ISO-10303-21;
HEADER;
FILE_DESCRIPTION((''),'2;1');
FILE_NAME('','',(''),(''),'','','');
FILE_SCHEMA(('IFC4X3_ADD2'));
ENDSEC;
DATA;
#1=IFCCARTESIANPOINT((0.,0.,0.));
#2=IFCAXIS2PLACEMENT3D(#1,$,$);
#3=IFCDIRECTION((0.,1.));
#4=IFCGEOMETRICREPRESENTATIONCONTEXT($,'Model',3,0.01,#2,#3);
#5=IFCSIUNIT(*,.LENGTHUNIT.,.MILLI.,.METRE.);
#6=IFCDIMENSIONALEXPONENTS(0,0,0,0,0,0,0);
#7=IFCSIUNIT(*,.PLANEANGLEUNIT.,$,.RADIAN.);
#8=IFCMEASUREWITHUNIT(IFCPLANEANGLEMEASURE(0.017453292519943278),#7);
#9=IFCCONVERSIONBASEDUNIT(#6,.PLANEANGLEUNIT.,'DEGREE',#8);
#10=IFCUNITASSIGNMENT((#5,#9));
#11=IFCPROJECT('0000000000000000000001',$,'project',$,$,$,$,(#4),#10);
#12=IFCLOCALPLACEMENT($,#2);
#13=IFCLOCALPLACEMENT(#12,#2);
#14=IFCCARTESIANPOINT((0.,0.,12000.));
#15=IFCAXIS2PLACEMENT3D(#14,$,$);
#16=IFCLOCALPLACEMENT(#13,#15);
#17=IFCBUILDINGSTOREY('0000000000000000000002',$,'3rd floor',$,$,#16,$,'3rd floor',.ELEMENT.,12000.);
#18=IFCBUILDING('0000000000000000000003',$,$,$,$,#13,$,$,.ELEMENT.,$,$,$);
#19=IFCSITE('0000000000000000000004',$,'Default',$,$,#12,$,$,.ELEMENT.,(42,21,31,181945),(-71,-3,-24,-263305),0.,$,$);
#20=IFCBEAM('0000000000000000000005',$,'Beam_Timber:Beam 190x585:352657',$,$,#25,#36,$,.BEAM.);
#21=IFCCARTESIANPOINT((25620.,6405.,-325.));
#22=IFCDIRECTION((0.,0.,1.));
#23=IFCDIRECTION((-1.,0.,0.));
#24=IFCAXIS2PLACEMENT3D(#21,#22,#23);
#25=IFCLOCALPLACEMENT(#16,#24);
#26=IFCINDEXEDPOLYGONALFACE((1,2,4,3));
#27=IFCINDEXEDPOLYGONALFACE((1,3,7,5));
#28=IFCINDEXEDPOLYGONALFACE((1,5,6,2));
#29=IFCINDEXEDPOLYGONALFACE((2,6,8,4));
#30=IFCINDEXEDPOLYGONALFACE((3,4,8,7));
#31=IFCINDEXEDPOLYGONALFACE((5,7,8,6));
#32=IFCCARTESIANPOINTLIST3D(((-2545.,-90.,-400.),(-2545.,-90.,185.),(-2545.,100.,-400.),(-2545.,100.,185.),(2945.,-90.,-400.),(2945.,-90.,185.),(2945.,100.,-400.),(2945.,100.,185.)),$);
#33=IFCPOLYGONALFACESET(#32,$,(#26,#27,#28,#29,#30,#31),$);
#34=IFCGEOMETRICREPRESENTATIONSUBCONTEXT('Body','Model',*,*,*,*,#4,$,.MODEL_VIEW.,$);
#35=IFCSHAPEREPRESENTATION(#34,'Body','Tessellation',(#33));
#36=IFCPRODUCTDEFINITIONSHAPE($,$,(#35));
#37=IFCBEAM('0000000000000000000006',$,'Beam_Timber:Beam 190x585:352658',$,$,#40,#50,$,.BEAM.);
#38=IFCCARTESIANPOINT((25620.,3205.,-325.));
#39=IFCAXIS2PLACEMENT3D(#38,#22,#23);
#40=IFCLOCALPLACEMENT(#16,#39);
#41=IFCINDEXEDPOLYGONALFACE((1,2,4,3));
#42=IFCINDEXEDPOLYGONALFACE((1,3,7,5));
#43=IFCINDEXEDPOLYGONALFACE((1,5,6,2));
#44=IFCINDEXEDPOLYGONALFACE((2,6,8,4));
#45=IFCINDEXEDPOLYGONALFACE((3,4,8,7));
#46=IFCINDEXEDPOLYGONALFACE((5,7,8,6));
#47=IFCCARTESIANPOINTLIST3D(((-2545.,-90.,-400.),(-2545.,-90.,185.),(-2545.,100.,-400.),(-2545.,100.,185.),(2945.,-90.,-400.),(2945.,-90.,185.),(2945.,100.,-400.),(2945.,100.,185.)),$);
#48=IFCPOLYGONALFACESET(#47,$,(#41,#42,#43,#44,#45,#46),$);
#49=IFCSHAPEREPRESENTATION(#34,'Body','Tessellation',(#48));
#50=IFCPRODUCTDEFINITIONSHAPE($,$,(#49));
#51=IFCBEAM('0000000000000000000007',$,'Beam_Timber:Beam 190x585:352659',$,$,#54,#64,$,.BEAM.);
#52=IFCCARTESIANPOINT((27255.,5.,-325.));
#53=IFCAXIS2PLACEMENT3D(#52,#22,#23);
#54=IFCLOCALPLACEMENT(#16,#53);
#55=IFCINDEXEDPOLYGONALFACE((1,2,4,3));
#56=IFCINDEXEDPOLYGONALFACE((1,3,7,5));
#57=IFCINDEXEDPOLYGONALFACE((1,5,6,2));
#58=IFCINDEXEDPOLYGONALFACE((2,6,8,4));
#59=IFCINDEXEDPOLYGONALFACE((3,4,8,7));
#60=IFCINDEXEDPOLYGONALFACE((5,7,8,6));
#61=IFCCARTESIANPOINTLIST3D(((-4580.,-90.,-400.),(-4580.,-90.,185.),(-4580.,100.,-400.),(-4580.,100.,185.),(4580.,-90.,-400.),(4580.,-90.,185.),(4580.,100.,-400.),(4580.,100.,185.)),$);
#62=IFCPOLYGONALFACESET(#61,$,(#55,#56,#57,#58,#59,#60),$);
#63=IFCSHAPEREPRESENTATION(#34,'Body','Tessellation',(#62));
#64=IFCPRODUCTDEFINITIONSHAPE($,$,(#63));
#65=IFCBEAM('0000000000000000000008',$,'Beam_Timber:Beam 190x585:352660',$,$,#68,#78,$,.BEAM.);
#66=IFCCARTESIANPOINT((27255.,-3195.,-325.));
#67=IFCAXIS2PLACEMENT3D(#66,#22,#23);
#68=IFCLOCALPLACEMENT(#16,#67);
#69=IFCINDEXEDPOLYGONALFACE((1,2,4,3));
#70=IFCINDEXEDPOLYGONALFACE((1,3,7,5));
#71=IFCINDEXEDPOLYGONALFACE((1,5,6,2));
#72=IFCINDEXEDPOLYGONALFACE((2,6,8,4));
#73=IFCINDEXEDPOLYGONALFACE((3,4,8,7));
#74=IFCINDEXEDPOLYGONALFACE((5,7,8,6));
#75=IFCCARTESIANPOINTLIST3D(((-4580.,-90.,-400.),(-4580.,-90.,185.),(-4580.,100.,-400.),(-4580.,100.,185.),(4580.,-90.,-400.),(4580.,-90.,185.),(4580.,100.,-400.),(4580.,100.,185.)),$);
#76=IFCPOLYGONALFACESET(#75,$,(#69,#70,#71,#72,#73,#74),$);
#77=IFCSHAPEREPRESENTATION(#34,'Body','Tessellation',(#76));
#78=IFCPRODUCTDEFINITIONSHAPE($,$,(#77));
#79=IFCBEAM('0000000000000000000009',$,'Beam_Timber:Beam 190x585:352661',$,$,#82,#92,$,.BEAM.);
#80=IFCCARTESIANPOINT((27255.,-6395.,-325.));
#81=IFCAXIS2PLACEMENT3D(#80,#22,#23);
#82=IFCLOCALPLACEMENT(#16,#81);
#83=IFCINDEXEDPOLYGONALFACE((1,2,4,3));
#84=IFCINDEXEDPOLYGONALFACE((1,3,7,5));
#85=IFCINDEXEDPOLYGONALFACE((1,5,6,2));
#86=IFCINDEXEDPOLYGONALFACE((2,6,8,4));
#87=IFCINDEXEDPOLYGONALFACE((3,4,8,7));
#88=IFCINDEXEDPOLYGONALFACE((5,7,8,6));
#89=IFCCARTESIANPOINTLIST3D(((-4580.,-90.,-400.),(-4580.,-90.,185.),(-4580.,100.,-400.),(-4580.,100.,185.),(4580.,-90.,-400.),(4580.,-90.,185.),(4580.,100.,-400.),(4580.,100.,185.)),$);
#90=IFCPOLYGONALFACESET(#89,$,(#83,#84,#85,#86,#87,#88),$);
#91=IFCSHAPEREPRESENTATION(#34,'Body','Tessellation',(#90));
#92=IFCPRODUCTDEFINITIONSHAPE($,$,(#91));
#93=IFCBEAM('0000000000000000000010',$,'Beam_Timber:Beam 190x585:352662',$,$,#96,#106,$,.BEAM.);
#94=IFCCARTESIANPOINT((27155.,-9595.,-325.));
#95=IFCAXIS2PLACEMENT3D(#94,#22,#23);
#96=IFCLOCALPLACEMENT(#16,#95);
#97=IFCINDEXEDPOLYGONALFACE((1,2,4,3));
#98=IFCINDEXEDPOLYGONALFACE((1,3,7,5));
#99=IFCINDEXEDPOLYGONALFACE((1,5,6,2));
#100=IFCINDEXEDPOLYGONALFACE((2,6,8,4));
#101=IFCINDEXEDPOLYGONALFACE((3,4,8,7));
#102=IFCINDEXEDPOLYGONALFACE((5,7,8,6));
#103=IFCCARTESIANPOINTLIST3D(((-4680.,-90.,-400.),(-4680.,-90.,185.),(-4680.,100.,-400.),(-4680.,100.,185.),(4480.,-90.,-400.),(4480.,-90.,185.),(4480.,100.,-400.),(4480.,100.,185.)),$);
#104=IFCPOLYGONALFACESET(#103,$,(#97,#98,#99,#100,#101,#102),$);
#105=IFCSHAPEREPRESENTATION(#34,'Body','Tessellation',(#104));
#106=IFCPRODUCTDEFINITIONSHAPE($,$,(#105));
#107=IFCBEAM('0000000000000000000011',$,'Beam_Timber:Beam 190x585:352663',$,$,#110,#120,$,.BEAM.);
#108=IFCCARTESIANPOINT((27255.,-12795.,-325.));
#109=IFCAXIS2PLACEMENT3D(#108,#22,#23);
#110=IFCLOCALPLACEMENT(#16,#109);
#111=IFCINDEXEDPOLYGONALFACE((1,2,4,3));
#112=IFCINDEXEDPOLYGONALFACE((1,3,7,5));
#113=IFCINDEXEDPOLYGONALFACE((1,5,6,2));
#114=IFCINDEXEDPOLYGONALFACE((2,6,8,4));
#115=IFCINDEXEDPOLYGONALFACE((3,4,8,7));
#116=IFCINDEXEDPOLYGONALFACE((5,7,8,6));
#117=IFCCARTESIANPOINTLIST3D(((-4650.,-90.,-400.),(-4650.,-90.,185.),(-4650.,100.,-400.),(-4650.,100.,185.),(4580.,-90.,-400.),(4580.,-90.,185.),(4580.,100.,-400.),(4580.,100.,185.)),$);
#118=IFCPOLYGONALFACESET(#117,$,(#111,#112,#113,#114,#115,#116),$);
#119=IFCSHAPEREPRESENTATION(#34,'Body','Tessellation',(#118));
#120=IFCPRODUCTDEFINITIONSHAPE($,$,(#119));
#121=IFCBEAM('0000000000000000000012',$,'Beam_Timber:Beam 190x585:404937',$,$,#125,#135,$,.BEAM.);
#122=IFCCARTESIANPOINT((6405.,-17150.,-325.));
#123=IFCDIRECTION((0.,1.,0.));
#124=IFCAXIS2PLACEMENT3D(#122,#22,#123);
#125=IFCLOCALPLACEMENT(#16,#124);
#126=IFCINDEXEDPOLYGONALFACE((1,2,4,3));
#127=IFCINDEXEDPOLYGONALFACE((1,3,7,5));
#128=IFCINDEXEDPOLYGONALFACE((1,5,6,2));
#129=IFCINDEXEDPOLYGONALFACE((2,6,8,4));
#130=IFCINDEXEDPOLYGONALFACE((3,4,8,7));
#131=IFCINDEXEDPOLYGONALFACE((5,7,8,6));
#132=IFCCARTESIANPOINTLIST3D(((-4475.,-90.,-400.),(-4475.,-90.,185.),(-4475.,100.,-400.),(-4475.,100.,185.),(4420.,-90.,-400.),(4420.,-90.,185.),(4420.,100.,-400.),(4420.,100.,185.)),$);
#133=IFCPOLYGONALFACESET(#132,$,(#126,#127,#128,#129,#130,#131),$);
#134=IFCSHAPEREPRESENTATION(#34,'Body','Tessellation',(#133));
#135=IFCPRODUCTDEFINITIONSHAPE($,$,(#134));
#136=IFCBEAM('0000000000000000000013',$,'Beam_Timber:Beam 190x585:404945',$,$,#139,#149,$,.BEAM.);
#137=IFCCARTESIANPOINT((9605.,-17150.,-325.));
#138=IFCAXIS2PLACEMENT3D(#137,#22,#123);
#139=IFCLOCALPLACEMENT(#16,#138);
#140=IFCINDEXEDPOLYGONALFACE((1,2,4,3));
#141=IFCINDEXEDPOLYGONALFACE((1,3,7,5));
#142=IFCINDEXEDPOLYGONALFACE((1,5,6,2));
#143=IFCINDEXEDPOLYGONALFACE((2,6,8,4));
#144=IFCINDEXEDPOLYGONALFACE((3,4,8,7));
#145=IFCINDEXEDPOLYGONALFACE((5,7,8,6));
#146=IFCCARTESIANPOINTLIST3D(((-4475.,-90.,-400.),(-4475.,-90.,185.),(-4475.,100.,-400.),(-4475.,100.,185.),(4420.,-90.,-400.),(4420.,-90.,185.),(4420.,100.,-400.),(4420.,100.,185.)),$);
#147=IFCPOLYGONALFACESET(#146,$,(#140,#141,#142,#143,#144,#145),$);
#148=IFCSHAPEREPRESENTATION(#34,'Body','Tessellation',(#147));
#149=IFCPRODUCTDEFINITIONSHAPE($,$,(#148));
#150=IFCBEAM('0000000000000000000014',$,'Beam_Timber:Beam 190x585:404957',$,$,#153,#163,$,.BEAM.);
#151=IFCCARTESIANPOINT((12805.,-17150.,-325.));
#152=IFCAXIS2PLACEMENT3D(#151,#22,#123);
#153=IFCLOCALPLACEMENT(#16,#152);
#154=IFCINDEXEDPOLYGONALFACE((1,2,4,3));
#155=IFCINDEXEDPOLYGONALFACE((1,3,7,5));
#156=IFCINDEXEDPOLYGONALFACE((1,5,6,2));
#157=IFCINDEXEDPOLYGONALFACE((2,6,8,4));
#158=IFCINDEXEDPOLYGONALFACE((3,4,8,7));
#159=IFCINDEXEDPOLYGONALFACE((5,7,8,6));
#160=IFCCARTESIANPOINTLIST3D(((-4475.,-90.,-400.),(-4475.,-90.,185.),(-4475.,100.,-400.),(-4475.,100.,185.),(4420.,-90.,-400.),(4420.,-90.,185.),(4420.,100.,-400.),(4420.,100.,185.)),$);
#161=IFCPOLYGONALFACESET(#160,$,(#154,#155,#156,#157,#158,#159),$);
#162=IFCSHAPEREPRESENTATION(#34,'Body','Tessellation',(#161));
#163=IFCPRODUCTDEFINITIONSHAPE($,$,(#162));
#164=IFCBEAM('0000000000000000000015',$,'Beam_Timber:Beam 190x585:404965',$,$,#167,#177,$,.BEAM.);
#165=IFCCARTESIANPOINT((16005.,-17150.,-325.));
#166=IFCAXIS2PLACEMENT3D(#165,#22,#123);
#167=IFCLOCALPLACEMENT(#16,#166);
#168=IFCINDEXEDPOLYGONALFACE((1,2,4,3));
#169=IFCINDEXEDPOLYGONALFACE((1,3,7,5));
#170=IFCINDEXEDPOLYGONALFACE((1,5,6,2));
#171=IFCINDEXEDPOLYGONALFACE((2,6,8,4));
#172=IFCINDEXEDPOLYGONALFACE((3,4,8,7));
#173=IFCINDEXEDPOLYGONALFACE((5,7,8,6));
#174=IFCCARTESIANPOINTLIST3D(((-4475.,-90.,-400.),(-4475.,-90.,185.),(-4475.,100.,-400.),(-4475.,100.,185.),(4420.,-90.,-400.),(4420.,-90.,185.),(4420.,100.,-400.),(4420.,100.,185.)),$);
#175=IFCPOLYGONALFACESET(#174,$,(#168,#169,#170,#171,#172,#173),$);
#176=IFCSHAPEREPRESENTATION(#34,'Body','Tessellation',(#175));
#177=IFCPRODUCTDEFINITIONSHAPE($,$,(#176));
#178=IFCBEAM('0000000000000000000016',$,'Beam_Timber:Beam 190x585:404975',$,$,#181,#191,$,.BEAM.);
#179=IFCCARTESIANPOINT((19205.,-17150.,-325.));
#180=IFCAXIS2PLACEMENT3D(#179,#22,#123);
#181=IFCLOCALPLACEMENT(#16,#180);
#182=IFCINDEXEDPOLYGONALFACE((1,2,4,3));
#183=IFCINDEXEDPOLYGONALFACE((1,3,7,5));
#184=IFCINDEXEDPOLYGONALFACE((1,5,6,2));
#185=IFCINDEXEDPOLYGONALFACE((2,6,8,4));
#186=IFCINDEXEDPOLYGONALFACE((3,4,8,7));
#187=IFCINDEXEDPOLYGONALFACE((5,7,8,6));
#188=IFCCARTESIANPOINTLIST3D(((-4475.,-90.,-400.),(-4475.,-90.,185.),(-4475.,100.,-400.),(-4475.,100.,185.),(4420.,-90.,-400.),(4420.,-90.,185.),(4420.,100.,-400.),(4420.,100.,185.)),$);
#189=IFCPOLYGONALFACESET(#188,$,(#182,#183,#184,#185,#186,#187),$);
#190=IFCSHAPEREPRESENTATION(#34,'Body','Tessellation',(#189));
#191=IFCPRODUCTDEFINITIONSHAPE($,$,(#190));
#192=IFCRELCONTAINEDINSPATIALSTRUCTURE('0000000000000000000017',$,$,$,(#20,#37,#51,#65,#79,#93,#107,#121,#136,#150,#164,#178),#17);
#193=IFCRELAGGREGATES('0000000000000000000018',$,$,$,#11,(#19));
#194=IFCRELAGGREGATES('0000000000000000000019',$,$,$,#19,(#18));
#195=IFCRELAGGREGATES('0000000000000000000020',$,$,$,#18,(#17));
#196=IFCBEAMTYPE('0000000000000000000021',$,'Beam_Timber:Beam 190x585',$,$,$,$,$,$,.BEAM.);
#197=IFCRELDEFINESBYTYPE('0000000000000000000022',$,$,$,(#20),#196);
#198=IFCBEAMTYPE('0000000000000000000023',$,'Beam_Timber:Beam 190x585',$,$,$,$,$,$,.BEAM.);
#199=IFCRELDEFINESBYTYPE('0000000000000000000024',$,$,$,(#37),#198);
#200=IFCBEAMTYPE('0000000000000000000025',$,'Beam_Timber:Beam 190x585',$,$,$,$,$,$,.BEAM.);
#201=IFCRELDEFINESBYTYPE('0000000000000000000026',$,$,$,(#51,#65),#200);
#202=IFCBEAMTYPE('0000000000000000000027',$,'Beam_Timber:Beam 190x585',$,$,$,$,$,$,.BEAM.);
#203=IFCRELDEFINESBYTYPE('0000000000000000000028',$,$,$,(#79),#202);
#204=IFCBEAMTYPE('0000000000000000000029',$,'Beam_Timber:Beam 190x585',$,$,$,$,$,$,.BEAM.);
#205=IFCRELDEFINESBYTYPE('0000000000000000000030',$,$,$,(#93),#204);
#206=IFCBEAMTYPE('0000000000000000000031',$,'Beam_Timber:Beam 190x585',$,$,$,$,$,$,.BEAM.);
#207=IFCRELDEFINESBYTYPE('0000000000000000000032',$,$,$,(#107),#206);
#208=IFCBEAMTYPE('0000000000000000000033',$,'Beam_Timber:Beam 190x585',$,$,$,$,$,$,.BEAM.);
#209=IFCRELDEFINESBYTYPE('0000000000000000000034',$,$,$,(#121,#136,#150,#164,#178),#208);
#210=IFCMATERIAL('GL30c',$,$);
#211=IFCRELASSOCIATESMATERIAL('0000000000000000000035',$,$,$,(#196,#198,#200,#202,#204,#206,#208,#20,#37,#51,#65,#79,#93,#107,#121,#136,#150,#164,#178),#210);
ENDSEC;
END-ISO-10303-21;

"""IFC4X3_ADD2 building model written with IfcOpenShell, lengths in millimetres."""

from ifc_helpers import new_model, entity, si_unit, converted_unit, direction, frame, origin, origin_2d_with_axis, place, context, subcontext, project, spatial, rectangle, extrude, source, transform, mapped, material, material_profile, profile_set, profile_usage, type_object, type_shapes, element, save


model = new_model("IFC4X3_ADD2")

# Units and contexts
model_context = context("Model", 3, precision=0.01, world=origin(), true_north=direction((0.0, 1.0)))
body_context = subcontext(model_context, "Body", "Model", "MODEL_VIEW")
ifc_project = project(units=[si_unit("LENGTHUNIT", "METRE", prefix="MILLI"), converted_unit("PLANEANGLEUNIT", "DEGREE", entity("IfcPlaneAngleMeasure", 0.017453292519943278), si_unit("PLANEANGLEUNIT", "RADIAN"), dimensions=[0, 0, 0, 0, 0, 0, 0])], contexts=[model_context])

# Site, building, storey
site_placement = place(None, origin())
site = spatial("IfcSite", under=ifc_project, at=site_placement, Name="Default", CompositionType="ELEMENT", RefLatitude=(42, 21, 31, 181945), RefLongitude=(-71, -3, -24, -263305), RefElevation=0.0)
building_placement = place(site_placement, origin())
building = spatial("IfcBuilding", under=site, at=building_placement, CompositionType="ELEMENT")
storey_placement = place(building_placement, frame((0.0, 0.0, 12000.0)))
storey = spatial("IfcBuildingStorey", under=building, at=storey_placement, Name="3rd floor", LongName="3rd floor", CompositionType="ELEMENT", Elevation=12000.0)

# Beams
ifc_material_1 = material(Name="GL30c")
ifc_material_profile_1 = material_profile(ifc_material_1, rectangle(XDim=5490.0, YDim=190.0, at=origin_2d_with_axis()), Name="Beam 190x585")
ifc_profile_set_1 = profile_set([ifc_material_profile_1], Name="Beam 190x585")
ifc_profile_usage_1 = profile_usage(ifc_profile_set_1, cardinal=8)
beam_type_1 = type_object("IfcBeamType", Name="Beam_Timber:Beam 190x585", PredefinedType="BEAM", material=ifc_profile_set_1)
shared_shape_1 = source(origin(), body_context, "Body", "SweptSolid", [
    extrude(rectangle(XDim=5490.0, YDim=190.0, at=origin_2d_with_axis()), frame((200.0, 5.0, -400.0), z_axis=(0.0, 0.0, 1.0), x_axis=(-1.0, 0.0, 0.0)), (0.0, 0.0, 1.0), 585.0),
])
type_shapes(beam_type_1, [shared_shape_1])
beam_1_placement = place(storey_placement, frame((25620.0, 6405.0, -325.0), z_axis=(0.0, 0.0, 1.0), x_axis=(-1.0, 0.0, 0.0)))
element("IfcBeam", 1, at=beam_1_placement, inside=storey, type_object=beam_type_1, material=ifc_profile_usage_1, Name="Beam_Timber:Beam 190x585:352657", PredefinedType="BEAM", context=body_context, shape_type="MappedRepresentation", body=[
    mapped(shared_shape_1, transform((0.0, 0.0, 0.0), scale=1.0)),
])
beam_type_2 = type_object("IfcBeamType", Name="Beam_Timber:Beam 190x585", PredefinedType="BEAM", material=ifc_profile_set_1)
shared_shape_2 = source(origin(), body_context, "Body", "SweptSolid", [
    extrude(rectangle(XDim=5490.0, YDim=190.0, at=origin_2d_with_axis()), frame((200.0, 5.0, -400.0), z_axis=(0.0, 0.0, 1.0), x_axis=(-1.0, 0.0, 0.0)), (0.0, 0.0, 1.0), 585.0),
])
type_shapes(beam_type_2, [shared_shape_2])
beam_2_placement = place(storey_placement, frame((25620.0, 3205.0, -325.0), z_axis=(0.0, 0.0, 1.0), x_axis=(-1.0, 0.0, 0.0)))
element("IfcBeam", 2, at=beam_2_placement, inside=storey, type_object=beam_type_2, material=ifc_profile_usage_1, Name="Beam_Timber:Beam 190x585:352658", PredefinedType="BEAM", context=body_context, shape_type="MappedRepresentation", body=[
    mapped(shared_shape_2, transform((0.0, 0.0, 0.0), scale=1.0)),
])
beam_type_3 = type_object("IfcBeamType", Name="Beam_Timber:Beam 190x585", PredefinedType="BEAM", material=ifc_profile_set_1)
shared_shape_3 = source(origin(), body_context, "Body", "SweptSolid", [
    extrude(rectangle(XDim=9160.0, YDim=190.0, at=origin_2d_with_axis()), frame((0.0, 5.0, -400.0), z_axis=(0.0, 0.0, 1.0), x_axis=(-1.0, 0.0, 0.0)), (0.0, 0.0, 1.0), 585.0),
])
type_shapes(beam_type_3, [shared_shape_3])
for number, where, z_axis, x_axis, name in (
    (3, (27255.0, 5.0, -325.0), (0.0, 0.0, 1.0), (-1.0, 0.0, 0.0), "Beam_Timber:Beam 190x585:352659"),
    (4, (27255.0, -3195.0, -325.0), (0.0, 0.0, 1.0), (-1.0, 0.0, 0.0), "Beam_Timber:Beam 190x585:352660"),
):
    element("IfcBeam", number, at=place(storey_placement, frame(where, z_axis=z_axis, x_axis=x_axis)), inside=storey, type_object=beam_type_3, material=ifc_profile_usage_1, Name=name, PredefinedType="BEAM", context=body_context, shape_type="MappedRepresentation", body=[
        mapped(shared_shape_3, transform((0.0, 0.0, 0.0), scale=1.0)),
    ])
beam_type_4 = type_object("IfcBeamType", Name="Beam_Timber:Beam 190x585", PredefinedType="BEAM", material=ifc_profile_set_1)
shared_shape_4 = source(origin(), body_context, "Body", "SweptSolid", [
    extrude(rectangle(XDim=9160.0, YDim=190.0, at=origin_2d_with_axis()), frame((0.0, 5.0, -400.0), z_axis=(0.0, 0.0, 1.0), x_axis=(-1.0, 0.0, 0.0)), (0.0, 0.0, 1.0), 585.0),
])
type_shapes(beam_type_4, [shared_shape_4])
beam_3_placement = place(storey_placement, frame((27255.0, -6395.0, -325.0), z_axis=(0.0, 0.0, 1.0), x_axis=(-1.0, 0.0, 0.0)))
element("IfcBeam", 5, at=beam_3_placement, inside=storey, type_object=beam_type_4, material=ifc_profile_usage_1, Name="Beam_Timber:Beam 190x585:352661", PredefinedType="BEAM", context=body_context, shape_type="MappedRepresentation", body=[
    mapped(shared_shape_4, transform((0.0, 0.0, 0.0), scale=1.0)),
])
beam_type_5 = type_object("IfcBeamType", Name="Beam_Timber:Beam 190x585", PredefinedType="BEAM", material=ifc_profile_set_1)
shared_shape_5 = source(origin(), body_context, "Body", "SweptSolid", [
    extrude(rectangle(XDim=9160.0, YDim=190.0, at=origin_2d_with_axis()), frame((-100.0, 5.0, -400.0), z_axis=(0.0, 0.0, 1.0), x_axis=(-1.0, 0.0, 0.0)), (0.0, 0.0, 1.0), 585.0),
])
type_shapes(beam_type_5, [shared_shape_5])
beam_4_placement = place(storey_placement, frame((27155.0, -9595.0, -325.0), z_axis=(0.0, 0.0, 1.0), x_axis=(-1.0, 0.0, 0.0)))
element("IfcBeam", 6, at=beam_4_placement, inside=storey, type_object=beam_type_5, material=ifc_profile_usage_1, Name="Beam_Timber:Beam 190x585:352662", PredefinedType="BEAM", context=body_context, shape_type="MappedRepresentation", body=[
    mapped(shared_shape_5, transform((0.0, 0.0, 0.0), scale=1.0)),
])
beam_type_6 = type_object("IfcBeamType", Name="Beam_Timber:Beam 190x585", PredefinedType="BEAM", material=ifc_profile_set_1)
shared_shape_6 = source(origin(), body_context, "Body", "SweptSolid", [
    extrude(rectangle(XDim=9230.0, YDim=190.0, at=origin_2d_with_axis()), frame((-35.0, 5.0, -400.0), z_axis=(0.0, 0.0, 1.0), x_axis=(-1.0, 0.0, 0.0)), (0.0, 0.0, 1.0), 585.0),
])
type_shapes(beam_type_6, [shared_shape_6])
beam_5_placement = place(storey_placement, frame((27255.0, -12795.0, -325.0), z_axis=(0.0, 0.0, 1.0), x_axis=(-1.0, 0.0, 0.0)))
element("IfcBeam", 7, at=beam_5_placement, inside=storey, type_object=beam_type_6, material=ifc_profile_usage_1, Name="Beam_Timber:Beam 190x585:352663", PredefinedType="BEAM", context=body_context, shape_type="MappedRepresentation", body=[
    mapped(shared_shape_6, transform((0.0, 0.0, 0.0), scale=1.0)),
])
beam_type_7 = type_object("IfcBeamType", Name="Beam_Timber:Beam 190x585", PredefinedType="BEAM", material=ifc_profile_set_1)
shared_shape_7 = source(origin(), body_context, "Body", "SweptSolid", [
    extrude(rectangle(XDim=8895.0, YDim=190.0, at=origin_2d_with_axis()), frame((-27.5, 5.0, -400.0), z_axis=(0.0, 0.0, 1.0), x_axis=(-1.0, 0.0, 0.0)), (0.0, 0.0, 1.0), 585.0),
])
type_shapes(beam_type_7, [shared_shape_7])
for number, where, z_axis, x_axis, name in (
    (8, (6405.0, -17150.0, -325.0), (0.0, 0.0, 1.0), (0.0, 1.0, 0.0), "Beam_Timber:Beam 190x585:404937"),
    (9, (9605.0, -17150.0, -325.0), (0.0, 0.0, 1.0), (0.0, 1.0, 0.0), "Beam_Timber:Beam 190x585:404945"),
    (10, (12805.0, -17150.0, -325.0), (0.0, 0.0, 1.0), (0.0, 1.0, 0.0), "Beam_Timber:Beam 190x585:404957"),
    (11, (16005.0, -17150.0, -325.0), (0.0, 0.0, 1.0), (0.0, 1.0, 0.0), "Beam_Timber:Beam 190x585:404965"),
    (12, (19205.0, -17150.0, -325.0), (0.0, 0.0, 1.0), (0.0, 1.0, 0.0), "Beam_Timber:Beam 190x585:404975"),
):
    element("IfcBeam", number, at=place(storey_placement, frame(where, z_axis=z_axis, x_axis=x_axis)), inside=storey, type_object=beam_type_7, material=ifc_profile_usage_1, Name=name, PredefinedType="BEAM", context=body_context, shape_type="MappedRepresentation", body=[
        mapped(shared_shape_7, transform((0.0, 0.0, 0.0), scale=1.0)),
    ])

save(model, "model.ifc")
